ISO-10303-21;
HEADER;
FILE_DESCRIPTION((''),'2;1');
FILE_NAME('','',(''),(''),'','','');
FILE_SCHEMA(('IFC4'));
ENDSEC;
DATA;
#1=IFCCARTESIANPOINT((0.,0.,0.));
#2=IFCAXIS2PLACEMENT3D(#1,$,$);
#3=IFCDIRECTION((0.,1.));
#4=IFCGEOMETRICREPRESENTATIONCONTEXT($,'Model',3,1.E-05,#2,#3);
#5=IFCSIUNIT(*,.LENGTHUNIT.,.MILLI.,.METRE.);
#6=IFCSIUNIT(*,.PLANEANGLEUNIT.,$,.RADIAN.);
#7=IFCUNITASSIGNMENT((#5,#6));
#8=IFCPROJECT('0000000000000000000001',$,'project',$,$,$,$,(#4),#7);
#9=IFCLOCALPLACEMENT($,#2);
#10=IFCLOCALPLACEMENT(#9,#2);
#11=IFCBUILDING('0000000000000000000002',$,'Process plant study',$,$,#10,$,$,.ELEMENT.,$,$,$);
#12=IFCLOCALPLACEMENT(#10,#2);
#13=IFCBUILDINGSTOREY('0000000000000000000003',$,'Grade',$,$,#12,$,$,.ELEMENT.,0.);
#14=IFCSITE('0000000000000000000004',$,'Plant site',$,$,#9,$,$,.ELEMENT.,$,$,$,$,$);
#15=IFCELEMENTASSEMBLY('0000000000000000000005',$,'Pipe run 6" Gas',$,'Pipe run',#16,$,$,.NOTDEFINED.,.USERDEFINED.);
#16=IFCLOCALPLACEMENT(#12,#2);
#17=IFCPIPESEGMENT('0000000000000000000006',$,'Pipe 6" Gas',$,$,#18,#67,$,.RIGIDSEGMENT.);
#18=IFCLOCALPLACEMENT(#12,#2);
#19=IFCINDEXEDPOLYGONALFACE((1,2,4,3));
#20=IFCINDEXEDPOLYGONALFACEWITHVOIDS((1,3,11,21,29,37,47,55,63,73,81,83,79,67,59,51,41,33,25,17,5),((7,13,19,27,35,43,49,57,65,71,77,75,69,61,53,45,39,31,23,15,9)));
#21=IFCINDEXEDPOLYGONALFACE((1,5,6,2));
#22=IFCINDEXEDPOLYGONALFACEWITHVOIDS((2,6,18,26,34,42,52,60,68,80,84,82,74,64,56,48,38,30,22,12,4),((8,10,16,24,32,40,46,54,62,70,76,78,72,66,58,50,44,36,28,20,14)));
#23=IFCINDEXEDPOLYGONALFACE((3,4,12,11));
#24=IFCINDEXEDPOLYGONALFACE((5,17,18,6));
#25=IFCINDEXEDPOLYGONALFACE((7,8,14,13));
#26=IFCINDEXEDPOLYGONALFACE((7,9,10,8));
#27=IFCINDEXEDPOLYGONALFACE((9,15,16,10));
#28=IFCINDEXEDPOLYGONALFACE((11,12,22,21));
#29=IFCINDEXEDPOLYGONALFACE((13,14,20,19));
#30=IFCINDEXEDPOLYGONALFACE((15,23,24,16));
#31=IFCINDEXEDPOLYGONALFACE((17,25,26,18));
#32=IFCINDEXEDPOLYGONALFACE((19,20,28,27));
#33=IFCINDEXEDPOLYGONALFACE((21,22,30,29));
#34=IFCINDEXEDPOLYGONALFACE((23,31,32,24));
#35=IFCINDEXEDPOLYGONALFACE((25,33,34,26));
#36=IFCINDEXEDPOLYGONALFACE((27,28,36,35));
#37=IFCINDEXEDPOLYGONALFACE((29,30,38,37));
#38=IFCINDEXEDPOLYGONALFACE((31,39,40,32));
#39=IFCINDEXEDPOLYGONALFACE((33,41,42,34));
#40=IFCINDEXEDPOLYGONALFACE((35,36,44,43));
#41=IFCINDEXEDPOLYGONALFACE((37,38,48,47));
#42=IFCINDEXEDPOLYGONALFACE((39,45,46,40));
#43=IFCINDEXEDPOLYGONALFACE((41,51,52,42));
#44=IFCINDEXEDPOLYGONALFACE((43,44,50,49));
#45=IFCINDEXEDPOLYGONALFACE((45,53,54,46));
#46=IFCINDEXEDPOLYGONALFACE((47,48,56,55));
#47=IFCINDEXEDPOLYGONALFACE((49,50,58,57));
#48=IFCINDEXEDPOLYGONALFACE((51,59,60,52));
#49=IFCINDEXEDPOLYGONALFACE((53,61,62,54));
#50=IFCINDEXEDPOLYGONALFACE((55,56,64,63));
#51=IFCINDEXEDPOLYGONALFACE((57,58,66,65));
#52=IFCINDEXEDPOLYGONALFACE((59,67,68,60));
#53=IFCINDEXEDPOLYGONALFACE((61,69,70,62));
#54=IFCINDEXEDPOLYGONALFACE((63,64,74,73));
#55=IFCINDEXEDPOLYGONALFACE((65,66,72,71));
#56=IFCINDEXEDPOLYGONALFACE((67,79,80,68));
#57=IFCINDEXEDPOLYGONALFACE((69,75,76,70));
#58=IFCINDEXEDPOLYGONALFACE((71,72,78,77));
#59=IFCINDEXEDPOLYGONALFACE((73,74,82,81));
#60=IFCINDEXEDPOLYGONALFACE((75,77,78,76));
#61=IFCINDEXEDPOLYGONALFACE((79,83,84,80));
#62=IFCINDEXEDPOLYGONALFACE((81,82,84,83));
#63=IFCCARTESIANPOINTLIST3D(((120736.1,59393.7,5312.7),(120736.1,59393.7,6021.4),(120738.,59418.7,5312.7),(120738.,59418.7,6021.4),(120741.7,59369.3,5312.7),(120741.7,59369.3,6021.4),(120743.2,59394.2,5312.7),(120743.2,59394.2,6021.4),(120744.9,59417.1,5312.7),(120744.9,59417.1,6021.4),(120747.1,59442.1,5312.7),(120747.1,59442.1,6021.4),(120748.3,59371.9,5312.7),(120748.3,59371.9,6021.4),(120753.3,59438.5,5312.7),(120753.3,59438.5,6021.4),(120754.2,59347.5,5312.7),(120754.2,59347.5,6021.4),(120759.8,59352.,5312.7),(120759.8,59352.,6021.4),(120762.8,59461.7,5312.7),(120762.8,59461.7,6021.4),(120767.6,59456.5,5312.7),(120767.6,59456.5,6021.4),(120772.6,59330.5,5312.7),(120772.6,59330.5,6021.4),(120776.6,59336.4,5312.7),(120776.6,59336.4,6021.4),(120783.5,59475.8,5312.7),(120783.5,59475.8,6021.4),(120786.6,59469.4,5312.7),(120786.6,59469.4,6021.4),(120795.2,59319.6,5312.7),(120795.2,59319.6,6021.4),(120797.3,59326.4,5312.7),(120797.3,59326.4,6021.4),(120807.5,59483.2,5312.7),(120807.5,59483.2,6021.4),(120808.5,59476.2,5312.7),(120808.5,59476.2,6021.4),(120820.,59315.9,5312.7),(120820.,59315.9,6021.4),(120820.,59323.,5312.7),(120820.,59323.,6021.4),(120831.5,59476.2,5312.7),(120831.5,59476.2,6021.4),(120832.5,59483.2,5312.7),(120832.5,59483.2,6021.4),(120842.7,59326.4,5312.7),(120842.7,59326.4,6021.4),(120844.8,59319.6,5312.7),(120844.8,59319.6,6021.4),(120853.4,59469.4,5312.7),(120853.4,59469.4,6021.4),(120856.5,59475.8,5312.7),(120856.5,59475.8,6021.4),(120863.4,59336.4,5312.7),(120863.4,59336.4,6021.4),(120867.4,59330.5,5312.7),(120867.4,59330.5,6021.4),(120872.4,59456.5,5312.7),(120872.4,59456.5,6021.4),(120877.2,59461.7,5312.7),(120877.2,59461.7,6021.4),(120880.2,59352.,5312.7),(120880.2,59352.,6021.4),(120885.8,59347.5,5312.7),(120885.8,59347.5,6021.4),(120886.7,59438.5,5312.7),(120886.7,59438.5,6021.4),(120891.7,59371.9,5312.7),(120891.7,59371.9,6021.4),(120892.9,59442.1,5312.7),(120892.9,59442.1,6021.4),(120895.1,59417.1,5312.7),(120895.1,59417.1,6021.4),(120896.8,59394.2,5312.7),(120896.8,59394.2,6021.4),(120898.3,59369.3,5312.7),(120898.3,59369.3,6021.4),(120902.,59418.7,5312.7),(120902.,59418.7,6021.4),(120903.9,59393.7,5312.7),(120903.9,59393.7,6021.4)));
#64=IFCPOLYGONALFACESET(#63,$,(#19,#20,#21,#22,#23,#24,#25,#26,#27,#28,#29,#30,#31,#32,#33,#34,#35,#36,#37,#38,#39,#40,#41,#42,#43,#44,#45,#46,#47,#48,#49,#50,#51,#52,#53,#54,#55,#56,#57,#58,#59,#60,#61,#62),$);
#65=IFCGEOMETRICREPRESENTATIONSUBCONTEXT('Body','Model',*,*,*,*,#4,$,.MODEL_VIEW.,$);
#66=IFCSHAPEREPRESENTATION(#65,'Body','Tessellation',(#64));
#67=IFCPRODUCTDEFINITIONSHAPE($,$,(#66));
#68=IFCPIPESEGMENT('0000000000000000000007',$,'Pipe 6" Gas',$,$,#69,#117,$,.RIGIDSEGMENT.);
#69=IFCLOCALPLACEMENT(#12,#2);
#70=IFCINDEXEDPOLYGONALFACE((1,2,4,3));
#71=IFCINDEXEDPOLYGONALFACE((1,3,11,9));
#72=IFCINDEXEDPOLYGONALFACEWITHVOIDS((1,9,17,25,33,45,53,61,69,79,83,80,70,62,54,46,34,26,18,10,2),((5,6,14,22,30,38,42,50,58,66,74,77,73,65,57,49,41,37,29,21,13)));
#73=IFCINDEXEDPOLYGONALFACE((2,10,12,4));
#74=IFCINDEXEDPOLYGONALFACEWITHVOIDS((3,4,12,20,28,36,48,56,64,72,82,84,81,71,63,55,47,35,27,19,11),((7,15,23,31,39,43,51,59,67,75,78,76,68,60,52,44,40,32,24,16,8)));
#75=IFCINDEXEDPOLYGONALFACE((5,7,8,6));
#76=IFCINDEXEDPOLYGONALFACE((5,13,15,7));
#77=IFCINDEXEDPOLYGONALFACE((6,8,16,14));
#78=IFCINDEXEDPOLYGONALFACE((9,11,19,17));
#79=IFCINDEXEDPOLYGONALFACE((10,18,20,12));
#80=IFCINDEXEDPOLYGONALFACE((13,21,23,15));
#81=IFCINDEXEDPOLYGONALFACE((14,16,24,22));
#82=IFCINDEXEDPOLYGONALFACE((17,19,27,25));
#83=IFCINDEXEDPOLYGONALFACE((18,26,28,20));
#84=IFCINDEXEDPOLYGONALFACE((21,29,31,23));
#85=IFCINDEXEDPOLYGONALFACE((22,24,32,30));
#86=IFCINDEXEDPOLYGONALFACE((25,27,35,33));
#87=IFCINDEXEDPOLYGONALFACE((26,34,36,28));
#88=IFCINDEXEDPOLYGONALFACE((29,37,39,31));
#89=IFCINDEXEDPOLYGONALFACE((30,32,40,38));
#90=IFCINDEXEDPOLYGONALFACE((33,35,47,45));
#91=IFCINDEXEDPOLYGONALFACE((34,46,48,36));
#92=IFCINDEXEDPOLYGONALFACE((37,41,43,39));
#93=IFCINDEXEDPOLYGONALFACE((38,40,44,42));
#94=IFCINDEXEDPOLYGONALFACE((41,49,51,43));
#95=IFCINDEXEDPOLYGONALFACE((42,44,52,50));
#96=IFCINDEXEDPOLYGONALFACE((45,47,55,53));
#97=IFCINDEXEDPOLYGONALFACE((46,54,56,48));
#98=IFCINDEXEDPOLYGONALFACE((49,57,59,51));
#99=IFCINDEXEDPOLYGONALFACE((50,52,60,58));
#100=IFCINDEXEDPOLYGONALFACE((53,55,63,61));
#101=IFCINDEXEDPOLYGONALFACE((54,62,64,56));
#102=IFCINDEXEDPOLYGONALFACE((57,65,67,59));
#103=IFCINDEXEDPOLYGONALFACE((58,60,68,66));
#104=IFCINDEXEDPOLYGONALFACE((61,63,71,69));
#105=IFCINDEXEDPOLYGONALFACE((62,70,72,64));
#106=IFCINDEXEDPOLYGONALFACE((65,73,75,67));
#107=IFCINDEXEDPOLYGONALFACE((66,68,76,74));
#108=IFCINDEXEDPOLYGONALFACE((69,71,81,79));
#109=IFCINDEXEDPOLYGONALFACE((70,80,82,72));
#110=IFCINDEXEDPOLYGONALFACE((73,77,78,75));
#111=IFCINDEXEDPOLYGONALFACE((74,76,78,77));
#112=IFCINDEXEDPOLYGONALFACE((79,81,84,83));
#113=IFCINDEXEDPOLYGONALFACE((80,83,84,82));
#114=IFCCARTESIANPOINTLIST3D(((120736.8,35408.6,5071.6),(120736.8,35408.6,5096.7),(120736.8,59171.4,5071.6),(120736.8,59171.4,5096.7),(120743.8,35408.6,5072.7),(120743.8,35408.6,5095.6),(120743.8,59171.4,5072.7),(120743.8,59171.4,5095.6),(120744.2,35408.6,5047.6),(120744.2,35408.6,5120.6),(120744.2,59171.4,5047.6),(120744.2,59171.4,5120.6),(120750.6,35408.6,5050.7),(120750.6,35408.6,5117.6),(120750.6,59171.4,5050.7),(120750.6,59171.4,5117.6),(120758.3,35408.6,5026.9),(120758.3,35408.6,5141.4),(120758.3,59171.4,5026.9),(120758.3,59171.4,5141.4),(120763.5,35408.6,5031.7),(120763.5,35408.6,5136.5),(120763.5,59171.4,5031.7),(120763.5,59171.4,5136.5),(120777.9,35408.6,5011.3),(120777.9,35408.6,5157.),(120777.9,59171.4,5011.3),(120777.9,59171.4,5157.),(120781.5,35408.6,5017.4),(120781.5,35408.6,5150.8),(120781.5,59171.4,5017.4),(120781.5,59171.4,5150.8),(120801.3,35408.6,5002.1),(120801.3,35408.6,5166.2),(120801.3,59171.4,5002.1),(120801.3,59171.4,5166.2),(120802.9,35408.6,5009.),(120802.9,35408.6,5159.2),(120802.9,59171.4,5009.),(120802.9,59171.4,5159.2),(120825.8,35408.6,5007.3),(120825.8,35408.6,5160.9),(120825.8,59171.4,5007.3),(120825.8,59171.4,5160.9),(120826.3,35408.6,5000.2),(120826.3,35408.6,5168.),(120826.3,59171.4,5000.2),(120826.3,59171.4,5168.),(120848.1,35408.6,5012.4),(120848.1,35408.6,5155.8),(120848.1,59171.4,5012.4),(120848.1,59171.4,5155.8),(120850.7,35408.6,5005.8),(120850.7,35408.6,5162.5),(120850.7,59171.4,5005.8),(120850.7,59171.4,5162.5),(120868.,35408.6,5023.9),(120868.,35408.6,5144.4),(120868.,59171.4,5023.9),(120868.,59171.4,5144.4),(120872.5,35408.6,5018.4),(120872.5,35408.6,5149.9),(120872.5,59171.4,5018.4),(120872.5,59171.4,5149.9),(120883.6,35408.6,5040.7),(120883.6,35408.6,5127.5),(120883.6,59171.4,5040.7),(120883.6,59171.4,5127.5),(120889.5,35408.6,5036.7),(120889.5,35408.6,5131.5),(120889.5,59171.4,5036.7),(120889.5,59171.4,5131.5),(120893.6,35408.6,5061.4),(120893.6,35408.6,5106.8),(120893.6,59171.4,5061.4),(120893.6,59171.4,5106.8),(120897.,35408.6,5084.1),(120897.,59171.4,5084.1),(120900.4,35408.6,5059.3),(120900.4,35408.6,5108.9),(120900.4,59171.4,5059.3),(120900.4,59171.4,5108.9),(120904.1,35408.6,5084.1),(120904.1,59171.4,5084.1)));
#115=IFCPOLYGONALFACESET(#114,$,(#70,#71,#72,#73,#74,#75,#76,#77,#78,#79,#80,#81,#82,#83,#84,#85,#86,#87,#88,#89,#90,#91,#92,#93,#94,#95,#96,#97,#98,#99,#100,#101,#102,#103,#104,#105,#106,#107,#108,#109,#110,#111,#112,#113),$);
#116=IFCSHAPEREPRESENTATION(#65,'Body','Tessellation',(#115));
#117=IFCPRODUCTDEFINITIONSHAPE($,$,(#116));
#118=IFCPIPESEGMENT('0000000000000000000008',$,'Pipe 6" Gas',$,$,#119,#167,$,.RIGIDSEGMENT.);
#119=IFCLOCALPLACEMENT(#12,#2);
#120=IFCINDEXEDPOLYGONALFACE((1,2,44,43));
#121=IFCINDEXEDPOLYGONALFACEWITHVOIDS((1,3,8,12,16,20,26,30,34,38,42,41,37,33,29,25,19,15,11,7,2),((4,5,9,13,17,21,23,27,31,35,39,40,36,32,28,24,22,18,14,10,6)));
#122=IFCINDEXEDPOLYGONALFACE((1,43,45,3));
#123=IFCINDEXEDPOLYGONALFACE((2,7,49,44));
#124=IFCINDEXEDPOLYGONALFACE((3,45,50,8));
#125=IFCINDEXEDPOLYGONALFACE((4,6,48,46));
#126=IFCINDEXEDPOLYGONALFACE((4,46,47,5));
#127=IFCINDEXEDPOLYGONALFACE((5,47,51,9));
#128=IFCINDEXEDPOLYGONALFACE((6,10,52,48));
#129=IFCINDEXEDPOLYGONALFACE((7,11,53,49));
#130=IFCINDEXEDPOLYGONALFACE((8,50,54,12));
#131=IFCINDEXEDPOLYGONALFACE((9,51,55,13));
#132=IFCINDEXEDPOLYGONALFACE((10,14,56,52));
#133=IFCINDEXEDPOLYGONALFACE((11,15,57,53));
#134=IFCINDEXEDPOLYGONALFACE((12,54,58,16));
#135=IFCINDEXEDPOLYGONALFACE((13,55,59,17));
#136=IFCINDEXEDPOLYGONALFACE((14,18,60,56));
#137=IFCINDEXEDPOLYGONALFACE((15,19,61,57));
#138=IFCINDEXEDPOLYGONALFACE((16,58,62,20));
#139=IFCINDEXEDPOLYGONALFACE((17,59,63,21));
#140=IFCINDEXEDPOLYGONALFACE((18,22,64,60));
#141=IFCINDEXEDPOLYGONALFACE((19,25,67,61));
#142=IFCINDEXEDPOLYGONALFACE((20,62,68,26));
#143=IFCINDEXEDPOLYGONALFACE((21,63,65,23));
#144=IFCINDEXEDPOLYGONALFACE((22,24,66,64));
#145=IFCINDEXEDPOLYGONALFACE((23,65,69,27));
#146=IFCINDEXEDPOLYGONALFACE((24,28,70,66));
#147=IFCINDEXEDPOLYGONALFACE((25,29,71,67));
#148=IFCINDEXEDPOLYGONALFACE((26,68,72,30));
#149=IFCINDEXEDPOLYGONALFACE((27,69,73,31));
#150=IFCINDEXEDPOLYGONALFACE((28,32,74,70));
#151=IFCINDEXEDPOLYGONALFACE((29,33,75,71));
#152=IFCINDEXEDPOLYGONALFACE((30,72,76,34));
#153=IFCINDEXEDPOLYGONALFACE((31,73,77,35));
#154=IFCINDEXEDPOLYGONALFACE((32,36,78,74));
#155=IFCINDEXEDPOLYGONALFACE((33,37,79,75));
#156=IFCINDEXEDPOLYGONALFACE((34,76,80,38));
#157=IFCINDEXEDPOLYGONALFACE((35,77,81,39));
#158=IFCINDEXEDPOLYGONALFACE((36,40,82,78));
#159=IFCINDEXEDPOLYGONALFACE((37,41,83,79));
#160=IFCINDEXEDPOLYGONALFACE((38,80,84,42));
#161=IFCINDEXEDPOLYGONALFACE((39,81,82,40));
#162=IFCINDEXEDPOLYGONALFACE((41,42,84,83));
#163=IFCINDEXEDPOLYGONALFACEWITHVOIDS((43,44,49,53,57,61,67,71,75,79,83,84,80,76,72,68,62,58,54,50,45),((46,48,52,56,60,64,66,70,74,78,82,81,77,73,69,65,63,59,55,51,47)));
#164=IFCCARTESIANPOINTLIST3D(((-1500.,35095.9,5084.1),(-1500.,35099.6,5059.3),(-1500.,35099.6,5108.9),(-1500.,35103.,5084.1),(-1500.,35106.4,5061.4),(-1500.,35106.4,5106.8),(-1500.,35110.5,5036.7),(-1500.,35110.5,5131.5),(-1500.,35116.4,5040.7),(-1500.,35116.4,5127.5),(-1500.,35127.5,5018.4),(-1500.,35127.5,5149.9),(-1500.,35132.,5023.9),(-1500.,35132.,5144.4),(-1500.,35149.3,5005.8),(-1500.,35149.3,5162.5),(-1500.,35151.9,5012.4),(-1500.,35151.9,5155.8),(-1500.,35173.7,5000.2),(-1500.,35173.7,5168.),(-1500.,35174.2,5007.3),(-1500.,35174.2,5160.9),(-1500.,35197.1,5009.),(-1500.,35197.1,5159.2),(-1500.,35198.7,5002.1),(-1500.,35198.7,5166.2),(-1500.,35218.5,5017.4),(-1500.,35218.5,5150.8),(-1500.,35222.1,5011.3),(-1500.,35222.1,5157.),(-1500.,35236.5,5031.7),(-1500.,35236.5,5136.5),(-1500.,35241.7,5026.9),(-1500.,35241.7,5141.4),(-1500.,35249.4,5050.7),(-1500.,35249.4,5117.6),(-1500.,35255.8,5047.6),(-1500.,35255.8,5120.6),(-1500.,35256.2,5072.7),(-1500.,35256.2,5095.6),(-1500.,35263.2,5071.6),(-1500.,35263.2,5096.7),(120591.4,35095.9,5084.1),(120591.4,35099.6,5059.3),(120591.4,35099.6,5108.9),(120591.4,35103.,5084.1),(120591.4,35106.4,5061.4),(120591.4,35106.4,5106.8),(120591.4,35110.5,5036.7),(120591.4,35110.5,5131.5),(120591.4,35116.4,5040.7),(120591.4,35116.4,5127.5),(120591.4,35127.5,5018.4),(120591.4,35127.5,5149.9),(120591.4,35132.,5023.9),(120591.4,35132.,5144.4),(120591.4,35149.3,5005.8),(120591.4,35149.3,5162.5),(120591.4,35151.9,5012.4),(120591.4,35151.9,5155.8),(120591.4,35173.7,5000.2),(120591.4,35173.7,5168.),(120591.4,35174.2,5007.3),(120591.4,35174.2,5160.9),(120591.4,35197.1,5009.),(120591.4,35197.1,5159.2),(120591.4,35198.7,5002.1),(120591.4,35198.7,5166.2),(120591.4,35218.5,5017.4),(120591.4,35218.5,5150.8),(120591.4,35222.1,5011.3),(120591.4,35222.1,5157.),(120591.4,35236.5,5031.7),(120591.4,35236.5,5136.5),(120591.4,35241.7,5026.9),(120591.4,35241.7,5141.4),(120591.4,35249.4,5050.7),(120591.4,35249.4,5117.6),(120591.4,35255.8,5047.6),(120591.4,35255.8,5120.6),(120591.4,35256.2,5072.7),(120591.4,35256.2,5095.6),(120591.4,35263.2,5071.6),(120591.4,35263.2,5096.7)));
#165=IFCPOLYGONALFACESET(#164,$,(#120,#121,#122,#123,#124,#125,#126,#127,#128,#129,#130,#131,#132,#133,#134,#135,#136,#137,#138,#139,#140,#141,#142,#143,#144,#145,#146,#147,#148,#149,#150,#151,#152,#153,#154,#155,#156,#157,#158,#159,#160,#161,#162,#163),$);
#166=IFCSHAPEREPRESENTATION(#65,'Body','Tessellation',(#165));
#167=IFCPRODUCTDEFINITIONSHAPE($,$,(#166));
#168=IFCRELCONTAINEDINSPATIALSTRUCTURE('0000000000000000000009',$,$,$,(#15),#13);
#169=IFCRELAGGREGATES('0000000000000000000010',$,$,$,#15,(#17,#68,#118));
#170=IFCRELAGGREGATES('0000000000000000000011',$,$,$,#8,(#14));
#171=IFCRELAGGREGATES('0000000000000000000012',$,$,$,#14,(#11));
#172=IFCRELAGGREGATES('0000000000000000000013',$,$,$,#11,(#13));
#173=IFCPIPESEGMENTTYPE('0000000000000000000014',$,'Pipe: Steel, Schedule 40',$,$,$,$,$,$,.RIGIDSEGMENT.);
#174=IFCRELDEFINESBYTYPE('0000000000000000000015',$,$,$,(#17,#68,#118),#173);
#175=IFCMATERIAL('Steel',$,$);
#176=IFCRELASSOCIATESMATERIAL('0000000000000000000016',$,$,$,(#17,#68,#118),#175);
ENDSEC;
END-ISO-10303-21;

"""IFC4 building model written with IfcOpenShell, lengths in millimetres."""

from ifc_helpers import new_model, si_unit, direction, frame, origin, origin_with_axes, origin_2d, place, context, subcontext, project, spatial, hollow_circle, extrude, material, type_object, element, aggregate, save


model = new_model("IFC4")

# Units and contexts
model_context = context("Model", 3, precision=1e-05, world=origin(), true_north=direction((0.0, 1.0)))
body_context = subcontext(model_context, "Body", "Model", "MODEL_VIEW")
ifc_project = project(units=[si_unit("LENGTHUNIT", "METRE", prefix="MILLI"), si_unit("PLANEANGLEUNIT", "RADIAN")], contexts=[model_context])

# Site, building, storey
site_placement = place(None, origin())
site = spatial("IfcSite", under=ifc_project, at=site_placement, Name="Plant site", CompositionType="ELEMENT")
building_placement = place(site_placement, origin())
building = spatial("IfcBuilding", under=site, at=building_placement, Name="Process plant study", CompositionType="ELEMENT")
storey_placement = place(building_placement, origin())
storey = spatial("IfcBuildingStorey", under=building, at=storey_placement, Name="Grade", CompositionType="ELEMENT", Elevation=0.0)

# Element assembly, pipe segments
ifc_material = material(Name="Steel")
pipe_segment_type = type_object("IfcPipeSegmentType", Name="Pipe: Steel, Schedule 40", PredefinedType="RIGIDSEGMENT")
assembly_1_placement = place(storey_placement, origin_with_axes())
assembly_1 = element("IfcElementAssembly", 1, at=assembly_1_placement, inside=storey, Name="Pipe run 6\" Gas", ObjectType="Pipe run", AssemblyPlace="NOTDEFINED", PredefinedType="USERDEFINED")
pipe_segment_1_placement = place(storey_placement, origin_with_axes())
pipe_segment_1 = element("IfcPipeSegment", 2, at=pipe_segment_1_placement, type_object=pipe_segment_type, material=ifc_material, Name="Pipe 6\" Gas", PredefinedType="RIGIDSEGMENT", context=body_context, shape_type="SweptSolid", body=[
    extrude(hollow_circle(Radius=84.1, WallThickness=7.1, at=origin_2d()), frame((120820.0, 59400.0, 6021.4), z_axis=(0.0, 0.0, -1.0), x_axis=(0.0, -1.0, 0.0)), (0.0, 0.0, 1.0), 708.7),
])
pipe_segment_2_placement = place(storey_placement, origin_with_axes())
pipe_segment_2 = element("IfcPipeSegment", 3, at=pipe_segment_2_placement, type_object=pipe_segment_type, material=ifc_material, Name="Pipe 6\" Gas", PredefinedType="RIGIDSEGMENT", context=body_context, shape_type="SweptSolid", body=[
    extrude(hollow_circle(Radius=84.1, WallThickness=7.1, at=origin_2d()), frame((120820.0, 59171.4, 5084.1), z_axis=(0.0, -1.0, 0.0), x_axis=(1.0, 0.0, 0.0)), (0.0, 0.0, 1.0), 23762.8),
])
pipe_segment_3_placement = place(storey_placement, origin_with_axes())
pipe_segment_3 = element("IfcPipeSegment", 4, at=pipe_segment_3_placement, type_object=pipe_segment_type, material=ifc_material, Name="Pipe 6\" Gas", PredefinedType="RIGIDSEGMENT", context=body_context, shape_type="SweptSolid", body=[
    extrude(hollow_circle(Radius=84.1, WallThickness=7.1, at=origin_2d()), frame((120591.4, 35180.0, 5084.1), z_axis=(-1.0, 0.0, 0.0), x_axis=(0.0, -1.0, 0.0)), (0.0, 0.0, 1.0), 122091.4),
])

aggregate(assembly_1, [pipe_segment_1, pipe_segment_2, pipe_segment_3])

save(model, "model.ifc")
